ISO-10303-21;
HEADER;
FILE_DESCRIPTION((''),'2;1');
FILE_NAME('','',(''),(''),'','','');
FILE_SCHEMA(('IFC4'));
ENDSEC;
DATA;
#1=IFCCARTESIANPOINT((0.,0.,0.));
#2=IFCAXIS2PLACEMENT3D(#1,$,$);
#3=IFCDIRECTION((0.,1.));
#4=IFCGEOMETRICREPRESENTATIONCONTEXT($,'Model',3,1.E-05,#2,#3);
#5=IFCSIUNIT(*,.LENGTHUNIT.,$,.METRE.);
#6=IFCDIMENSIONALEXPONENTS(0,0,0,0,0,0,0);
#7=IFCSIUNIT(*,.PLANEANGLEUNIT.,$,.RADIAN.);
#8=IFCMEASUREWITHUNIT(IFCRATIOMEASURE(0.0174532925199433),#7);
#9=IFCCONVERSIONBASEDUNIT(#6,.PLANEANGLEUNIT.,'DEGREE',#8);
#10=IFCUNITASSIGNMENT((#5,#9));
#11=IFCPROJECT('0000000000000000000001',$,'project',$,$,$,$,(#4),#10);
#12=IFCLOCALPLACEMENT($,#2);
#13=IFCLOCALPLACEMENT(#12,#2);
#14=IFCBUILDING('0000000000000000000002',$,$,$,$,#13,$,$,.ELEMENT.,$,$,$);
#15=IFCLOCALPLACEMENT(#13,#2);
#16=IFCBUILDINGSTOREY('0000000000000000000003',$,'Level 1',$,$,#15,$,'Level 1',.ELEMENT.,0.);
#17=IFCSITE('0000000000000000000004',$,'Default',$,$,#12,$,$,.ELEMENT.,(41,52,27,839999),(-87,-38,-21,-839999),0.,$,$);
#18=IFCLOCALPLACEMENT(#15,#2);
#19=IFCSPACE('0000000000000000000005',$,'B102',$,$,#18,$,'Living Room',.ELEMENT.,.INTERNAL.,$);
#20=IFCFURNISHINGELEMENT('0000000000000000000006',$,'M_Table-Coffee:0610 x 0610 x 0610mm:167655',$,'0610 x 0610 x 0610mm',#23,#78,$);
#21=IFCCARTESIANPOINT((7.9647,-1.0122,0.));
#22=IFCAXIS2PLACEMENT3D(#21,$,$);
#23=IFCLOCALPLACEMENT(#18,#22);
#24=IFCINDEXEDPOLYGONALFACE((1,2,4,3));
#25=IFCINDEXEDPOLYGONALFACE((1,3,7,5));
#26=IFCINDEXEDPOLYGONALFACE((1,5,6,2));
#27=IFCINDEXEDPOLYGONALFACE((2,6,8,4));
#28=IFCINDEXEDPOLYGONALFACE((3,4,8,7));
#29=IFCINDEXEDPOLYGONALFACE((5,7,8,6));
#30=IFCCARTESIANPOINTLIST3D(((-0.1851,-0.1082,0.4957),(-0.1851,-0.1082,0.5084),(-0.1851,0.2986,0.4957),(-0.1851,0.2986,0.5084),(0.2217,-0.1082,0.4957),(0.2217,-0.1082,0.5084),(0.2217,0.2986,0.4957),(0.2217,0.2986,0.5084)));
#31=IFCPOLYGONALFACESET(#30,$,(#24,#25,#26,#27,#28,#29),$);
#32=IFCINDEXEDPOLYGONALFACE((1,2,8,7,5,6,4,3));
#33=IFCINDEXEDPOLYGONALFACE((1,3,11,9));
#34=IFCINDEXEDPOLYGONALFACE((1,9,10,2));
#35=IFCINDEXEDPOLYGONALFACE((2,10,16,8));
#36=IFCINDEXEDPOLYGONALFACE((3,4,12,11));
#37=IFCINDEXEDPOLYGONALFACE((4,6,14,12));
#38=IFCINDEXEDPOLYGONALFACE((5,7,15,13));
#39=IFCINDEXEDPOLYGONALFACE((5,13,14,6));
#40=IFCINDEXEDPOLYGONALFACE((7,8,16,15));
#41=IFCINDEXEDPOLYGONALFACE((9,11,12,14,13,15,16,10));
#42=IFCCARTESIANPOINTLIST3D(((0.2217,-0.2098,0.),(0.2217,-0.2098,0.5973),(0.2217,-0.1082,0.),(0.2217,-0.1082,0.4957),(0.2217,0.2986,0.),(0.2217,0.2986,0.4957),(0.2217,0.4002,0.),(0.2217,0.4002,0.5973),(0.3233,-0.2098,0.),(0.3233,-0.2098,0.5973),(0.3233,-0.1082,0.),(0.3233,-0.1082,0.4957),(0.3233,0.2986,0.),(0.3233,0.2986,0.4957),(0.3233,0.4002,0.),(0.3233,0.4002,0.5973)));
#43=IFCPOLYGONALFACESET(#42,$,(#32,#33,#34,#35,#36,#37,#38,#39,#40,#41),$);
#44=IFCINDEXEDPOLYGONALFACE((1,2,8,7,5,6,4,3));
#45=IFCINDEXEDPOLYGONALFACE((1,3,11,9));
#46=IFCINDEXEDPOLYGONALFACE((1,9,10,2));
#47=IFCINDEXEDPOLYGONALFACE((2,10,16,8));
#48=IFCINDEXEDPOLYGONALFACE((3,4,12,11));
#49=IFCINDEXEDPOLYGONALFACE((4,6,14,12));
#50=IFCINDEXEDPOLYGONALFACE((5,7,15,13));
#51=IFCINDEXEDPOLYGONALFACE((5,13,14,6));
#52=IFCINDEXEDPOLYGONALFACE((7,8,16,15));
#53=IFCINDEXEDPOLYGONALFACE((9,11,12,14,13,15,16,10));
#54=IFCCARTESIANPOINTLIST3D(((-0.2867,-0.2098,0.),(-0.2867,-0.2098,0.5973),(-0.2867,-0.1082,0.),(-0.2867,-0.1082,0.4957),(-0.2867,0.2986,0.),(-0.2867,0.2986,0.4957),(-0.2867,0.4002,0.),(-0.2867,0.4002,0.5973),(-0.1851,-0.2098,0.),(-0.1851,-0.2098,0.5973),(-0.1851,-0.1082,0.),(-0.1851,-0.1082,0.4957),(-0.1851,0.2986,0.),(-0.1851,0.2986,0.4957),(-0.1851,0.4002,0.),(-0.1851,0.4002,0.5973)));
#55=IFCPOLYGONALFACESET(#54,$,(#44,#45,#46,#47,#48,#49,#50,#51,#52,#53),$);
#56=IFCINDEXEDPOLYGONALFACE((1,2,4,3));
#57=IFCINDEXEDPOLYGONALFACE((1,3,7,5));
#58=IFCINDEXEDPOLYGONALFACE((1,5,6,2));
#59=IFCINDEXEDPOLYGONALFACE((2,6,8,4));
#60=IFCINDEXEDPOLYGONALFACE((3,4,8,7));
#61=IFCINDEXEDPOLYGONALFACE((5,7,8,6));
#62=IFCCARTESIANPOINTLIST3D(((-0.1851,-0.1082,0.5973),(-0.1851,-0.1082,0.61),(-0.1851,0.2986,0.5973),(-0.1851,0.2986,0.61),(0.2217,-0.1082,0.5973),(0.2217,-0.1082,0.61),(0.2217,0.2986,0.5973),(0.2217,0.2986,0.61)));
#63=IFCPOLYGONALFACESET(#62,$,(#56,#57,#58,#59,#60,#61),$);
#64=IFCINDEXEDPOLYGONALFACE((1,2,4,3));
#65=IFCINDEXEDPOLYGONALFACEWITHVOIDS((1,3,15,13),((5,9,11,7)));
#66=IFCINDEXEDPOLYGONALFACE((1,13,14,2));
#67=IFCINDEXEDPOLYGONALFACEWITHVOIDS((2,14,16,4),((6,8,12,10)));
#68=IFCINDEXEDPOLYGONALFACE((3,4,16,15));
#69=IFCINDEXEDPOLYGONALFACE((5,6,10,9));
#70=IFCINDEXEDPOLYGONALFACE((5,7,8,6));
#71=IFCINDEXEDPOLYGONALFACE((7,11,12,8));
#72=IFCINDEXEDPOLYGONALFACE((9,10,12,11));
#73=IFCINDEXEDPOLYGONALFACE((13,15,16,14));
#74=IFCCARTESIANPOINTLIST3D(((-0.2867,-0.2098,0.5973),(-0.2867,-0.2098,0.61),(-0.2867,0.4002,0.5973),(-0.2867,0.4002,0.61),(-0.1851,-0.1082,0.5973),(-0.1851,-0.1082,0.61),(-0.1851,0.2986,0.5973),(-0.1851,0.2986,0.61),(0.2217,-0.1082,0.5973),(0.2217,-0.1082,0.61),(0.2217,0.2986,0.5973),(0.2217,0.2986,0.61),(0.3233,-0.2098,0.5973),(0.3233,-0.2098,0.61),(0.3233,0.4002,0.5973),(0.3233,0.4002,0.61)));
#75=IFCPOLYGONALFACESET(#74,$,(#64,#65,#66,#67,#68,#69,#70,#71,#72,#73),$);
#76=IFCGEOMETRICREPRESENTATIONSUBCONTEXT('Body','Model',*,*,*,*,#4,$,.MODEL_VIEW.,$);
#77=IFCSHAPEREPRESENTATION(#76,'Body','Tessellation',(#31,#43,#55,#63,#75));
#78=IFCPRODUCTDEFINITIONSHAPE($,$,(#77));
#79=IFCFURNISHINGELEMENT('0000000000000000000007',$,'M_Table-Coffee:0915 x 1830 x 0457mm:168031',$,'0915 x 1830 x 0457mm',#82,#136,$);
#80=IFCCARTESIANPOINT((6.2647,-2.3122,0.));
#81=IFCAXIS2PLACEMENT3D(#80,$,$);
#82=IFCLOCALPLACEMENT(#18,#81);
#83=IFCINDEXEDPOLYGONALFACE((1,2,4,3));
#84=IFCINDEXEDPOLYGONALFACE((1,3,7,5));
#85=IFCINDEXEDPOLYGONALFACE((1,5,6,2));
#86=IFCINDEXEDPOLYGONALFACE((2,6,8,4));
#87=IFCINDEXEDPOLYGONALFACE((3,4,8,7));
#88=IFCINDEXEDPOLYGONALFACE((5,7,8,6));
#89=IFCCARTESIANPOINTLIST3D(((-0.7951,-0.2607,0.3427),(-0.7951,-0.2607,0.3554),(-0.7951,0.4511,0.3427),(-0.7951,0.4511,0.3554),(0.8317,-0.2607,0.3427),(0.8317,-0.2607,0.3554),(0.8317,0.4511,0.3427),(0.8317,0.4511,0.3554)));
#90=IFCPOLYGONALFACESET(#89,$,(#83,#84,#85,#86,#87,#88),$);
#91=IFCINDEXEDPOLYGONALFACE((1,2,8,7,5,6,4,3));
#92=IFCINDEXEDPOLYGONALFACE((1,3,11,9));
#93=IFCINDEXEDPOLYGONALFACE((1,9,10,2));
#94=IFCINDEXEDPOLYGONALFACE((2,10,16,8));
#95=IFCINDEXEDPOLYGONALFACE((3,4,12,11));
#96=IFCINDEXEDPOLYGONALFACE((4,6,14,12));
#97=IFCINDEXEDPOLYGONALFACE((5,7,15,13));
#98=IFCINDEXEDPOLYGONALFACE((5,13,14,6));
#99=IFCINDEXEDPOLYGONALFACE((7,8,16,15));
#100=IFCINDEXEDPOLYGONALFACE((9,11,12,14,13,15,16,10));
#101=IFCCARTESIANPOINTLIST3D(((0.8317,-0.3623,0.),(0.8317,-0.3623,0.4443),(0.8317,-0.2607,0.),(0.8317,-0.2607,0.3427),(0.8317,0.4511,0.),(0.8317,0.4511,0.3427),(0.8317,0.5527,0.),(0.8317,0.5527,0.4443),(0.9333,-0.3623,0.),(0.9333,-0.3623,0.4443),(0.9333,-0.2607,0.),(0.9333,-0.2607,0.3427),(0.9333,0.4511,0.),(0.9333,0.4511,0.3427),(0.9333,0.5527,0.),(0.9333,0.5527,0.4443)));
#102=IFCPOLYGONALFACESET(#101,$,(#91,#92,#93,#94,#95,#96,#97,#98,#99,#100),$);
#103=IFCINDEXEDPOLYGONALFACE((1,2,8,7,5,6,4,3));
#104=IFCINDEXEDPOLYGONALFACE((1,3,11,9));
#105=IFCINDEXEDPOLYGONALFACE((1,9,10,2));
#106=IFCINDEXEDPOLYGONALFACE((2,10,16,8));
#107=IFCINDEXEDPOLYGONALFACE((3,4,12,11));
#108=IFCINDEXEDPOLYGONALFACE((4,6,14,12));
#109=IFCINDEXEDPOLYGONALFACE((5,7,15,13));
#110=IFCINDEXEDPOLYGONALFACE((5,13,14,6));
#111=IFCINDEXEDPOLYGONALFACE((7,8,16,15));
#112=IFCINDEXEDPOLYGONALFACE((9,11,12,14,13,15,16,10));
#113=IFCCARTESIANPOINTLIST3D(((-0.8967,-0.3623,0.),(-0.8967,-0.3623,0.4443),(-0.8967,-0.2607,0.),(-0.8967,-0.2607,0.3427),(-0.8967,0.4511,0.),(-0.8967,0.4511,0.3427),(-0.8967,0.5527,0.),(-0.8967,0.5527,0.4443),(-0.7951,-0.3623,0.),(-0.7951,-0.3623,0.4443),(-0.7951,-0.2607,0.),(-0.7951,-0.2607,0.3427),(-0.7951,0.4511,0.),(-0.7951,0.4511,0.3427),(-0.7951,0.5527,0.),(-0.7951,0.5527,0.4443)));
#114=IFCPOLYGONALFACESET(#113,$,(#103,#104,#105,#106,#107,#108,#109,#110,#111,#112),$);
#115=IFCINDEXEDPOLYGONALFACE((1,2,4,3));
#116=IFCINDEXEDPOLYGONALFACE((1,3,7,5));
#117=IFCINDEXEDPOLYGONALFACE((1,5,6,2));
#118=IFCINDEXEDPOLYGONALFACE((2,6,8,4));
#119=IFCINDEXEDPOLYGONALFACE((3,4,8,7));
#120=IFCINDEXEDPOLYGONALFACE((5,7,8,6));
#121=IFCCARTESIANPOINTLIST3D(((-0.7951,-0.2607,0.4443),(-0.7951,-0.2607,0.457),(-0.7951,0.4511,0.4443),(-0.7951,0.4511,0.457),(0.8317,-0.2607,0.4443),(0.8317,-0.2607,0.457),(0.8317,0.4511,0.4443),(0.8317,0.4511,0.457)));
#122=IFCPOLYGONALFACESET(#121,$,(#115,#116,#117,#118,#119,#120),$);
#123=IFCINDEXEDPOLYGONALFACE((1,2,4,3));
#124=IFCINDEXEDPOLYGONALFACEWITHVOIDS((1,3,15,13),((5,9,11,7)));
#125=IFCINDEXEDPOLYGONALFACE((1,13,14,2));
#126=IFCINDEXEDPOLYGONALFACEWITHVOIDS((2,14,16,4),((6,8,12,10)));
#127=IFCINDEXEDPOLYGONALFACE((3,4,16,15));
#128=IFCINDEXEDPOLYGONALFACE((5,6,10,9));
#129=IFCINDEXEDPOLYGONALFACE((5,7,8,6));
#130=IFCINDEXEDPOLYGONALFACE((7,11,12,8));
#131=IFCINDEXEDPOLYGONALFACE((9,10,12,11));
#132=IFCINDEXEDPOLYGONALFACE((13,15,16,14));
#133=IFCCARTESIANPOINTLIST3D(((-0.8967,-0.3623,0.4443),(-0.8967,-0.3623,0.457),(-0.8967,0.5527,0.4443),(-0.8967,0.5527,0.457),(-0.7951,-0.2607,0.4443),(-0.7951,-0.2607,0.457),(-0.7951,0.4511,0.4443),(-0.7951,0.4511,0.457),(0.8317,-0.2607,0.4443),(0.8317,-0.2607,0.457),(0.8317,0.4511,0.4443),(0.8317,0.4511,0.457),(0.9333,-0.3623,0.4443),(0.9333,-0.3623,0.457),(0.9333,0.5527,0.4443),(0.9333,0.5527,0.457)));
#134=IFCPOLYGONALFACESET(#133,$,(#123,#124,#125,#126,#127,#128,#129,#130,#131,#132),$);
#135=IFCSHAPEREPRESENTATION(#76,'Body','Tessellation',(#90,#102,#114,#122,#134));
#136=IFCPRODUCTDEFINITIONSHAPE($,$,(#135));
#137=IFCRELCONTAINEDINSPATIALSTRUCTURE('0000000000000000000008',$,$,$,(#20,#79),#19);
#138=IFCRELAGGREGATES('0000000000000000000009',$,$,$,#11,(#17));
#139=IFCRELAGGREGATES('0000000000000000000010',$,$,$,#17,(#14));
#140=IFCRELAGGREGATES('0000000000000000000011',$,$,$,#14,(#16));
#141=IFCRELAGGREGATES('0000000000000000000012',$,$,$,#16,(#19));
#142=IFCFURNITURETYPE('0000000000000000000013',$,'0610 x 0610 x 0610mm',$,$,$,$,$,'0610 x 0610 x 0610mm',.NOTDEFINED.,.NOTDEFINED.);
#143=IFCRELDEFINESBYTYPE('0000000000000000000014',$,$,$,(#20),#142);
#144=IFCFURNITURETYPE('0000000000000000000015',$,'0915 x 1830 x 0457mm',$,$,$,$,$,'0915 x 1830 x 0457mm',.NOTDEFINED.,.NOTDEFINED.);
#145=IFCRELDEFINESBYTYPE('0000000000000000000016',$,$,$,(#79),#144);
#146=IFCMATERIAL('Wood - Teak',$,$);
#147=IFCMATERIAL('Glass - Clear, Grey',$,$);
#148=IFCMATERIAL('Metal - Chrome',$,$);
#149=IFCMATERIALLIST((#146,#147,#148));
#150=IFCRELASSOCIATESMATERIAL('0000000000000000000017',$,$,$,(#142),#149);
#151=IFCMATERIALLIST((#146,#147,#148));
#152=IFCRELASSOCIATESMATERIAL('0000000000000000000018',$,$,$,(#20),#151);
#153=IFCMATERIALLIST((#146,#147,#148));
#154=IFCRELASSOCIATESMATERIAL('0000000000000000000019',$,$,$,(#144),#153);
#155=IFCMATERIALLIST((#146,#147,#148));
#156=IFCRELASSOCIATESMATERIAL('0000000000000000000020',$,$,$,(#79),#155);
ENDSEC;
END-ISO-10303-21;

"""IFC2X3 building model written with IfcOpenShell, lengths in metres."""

from ifc_helpers import new_model, entity, si_unit, converted_unit, direction, frame, origin, origin_2d_with_axis, place, context, subcontext, project, spatial, polyline, rectangle, outline, extrude, source, transform, mapped, material, material_list, type_object, type_shapes, element, save


model = new_model("IFC2X3")

# Units and contexts
model_context = context("Model", 3, precision=1e-05, world=origin(), true_north=direction((0.0, 1.0)))
body_context = subcontext(model_context, "Body", "Model", "MODEL_VIEW")
ifc_project = project(units=[si_unit("LENGTHUNIT", "METRE"), converted_unit("PLANEANGLEUNIT", "DEGREE", entity("IfcRatioMeasure", 0.0174532925199433), si_unit("PLANEANGLEUNIT", "RADIAN"), dimensions=[0, 0, 0, 0, 0, 0, 0])], contexts=[model_context])

# Site, building, storey
site_placement = place(None, origin())
site = spatial("IfcSite", under=ifc_project, at=site_placement, Name="Default", CompositionType="ELEMENT", RefLatitude=(41, 52, 27, 839999), RefLongitude=(-87, -38, -21, -839999), RefElevation=0.0)
building_placement = place(site_placement, origin())
building = spatial("IfcBuilding", under=site, at=building_placement, CompositionType="ELEMENT")
storey_placement = place(building_placement, origin())
storey = spatial("IfcBuildingStorey", under=building, at=storey_placement, Name="Level 1", LongName="Level 1", CompositionType="ELEMENT", Elevation=0.0)

# Shared definitions
space_placement = place(storey_placement, origin())
space = spatial("IfcSpace", under=storey, at=space_placement, Name="B102", LongName="Living Room", CompositionType="ELEMENT", InteriorOrExteriorSpace="INTERNAL")

# Furnishing elements
ifc_material_1 = material(Name="Wood - Teak")
ifc_material_2 = material(Name="Glass - Clear, Grey")
ifc_material_3 = material(Name="Metal - Chrome")
ifc_material_list_1 = material_list([ifc_material_1, ifc_material_2, ifc_material_3])
ifc_material_list_2 = material_list([ifc_material_1, ifc_material_2, ifc_material_3])
furniture_type_1 = type_object("IfcFurnitureType", Name="0610 x 0610 x 0610mm", ElementType="0610 x 0610 x 0610mm", AssemblyPlace="NOTDEFINED", material=ifc_material_list_2)
shared_shape_1 = source(origin(), body_context, "Body", "SweptSolid", [
    extrude(rectangle(XDim=0.4068, YDim=0.4068, at=origin_2d_with_axis()), frame((0.0183, 0.0952, 0.4957), z_axis=(0.0, 0.0, 1.0), x_axis=(-1.0, 0.0, 0.0)), (0.0, 0.0, 1.0), 0.0127),
    extrude(outline(polyline([(-0.2732, -0.305), (0.324, -0.305), (0.324, 0.305), (-0.2732, 0.305), (-0.2732, 0.2034), (0.2225, 0.2034), (0.2225, -0.2034), (-0.2732, -0.2034), (-0.2732, -0.305)])), frame((0.2217, 0.0952, 0.2732), z_axis=(1.0, 0.0, 0.0), x_axis=(0.0, 0.0, 1.0)), (0.0, 0.0, 1.0), 0.1016),
    extrude(outline(polyline([(-0.305, -0.3241), (0.305, -0.3241), (0.305, 0.2733), (0.2034, 0.2733), (0.2034, -0.2224), (-0.2034, -0.2224), (-0.2034, 0.2733), (-0.305, 0.2733), (-0.305, -0.3241)])), frame((-0.2867, 0.0952, 0.2733), z_axis=(1.0, 0.0, 0.0), x_axis=(0.0, -1.0, 0.0)), (0.0, 0.0, 1.0), 0.1016),
    extrude(rectangle(XDim=0.4068, YDim=0.4068, at=origin_2d_with_axis()), frame((0.0183, 0.0952, 0.5973), z_axis=(0.0, 0.0, 1.0), x_axis=(-1.0, 0.0, 0.0)), (0.0, 0.0, 1.0), 0.0127),
    extrude(outline(polyline([(-0.305, -0.305), (0.305, -0.305), (0.305, 0.305), (-0.305, 0.305), (-0.305, -0.305)]), holes=[polyline([(-0.2034, -0.2034), (-0.2034, 0.2034), (0.2034, 0.2034), (0.2034, -0.2034), (-0.2034, -0.2034)])]), frame((0.0183, 0.0952, 0.5973), z_axis=(0.0, 0.0, 1.0), x_axis=(-1.0, 0.0, 0.0)), (0.0, 0.0, 1.0), 0.0127),
])
type_shapes(furniture_type_1, [shared_shape_1])
furnishing_1_placement = place(space_placement, frame((7.9647, -1.0122, 0.0)))
element("IfcFurnishingElement", 1, at=furnishing_1_placement, inside=space, type_object=furniture_type_1, material=ifc_material_list_1, Name="M_Table-Coffee:0610 x 0610 x 0610mm:167655", ObjectType="0610 x 0610 x 0610mm", context=body_context, shape_type="MappedRepresentation", body=[
    mapped(shared_shape_1, transform((0.0, 0.0, 0.0), scale=1.0)),
])
ifc_material_list_3 = material_list([ifc_material_1, ifc_material_2, ifc_material_3])
ifc_material_list_4 = material_list([ifc_material_1, ifc_material_2, ifc_material_3])
furniture_type_2 = type_object("IfcFurnitureType", Name="0915 x 1830 x 0457mm", ElementType="0915 x 1830 x 0457mm", AssemblyPlace="NOTDEFINED", material=ifc_material_list_4)
shared_shape_2 = source(origin(), body_context, "Body", "SweptSolid", [
    extrude(rectangle(XDim=1.6268, YDim=0.7118, at=origin_2d_with_axis()), frame((0.0183, 0.0952, 0.3427), z_axis=(0.0, 0.0, 1.0), x_axis=(-1.0, 0.0, 0.0)), (0.0, 0.0, 1.0), 0.0127),
    extrude(outline(polyline([(-0.1967, -0.4575), (0.2475, -0.4575), (0.2475, 0.4575), (-0.1967, 0.4575), (-0.1967, 0.3559), (0.146, 0.3559), (0.146, -0.3559), (-0.1967, -0.3559), (-0.1967, -0.4575)])), frame((0.8317, 0.0952, 0.1967), z_axis=(1.0, 0.0, 0.0), x_axis=(0.0, 0.0, 1.0)), (0.0, 0.0, 1.0), 0.1016),
    extrude(outline(polyline([(-0.4575, -0.2476), (0.4575, -0.2476), (0.4575, 0.1968), (0.3559, 0.1968), (0.3559, -0.1459), (-0.3559, -0.1459), (-0.3559, 0.1968), (-0.4575, 0.1968), (-0.4575, -0.2476)])), frame((-0.8967, 0.0952, 0.1968), z_axis=(1.0, 0.0, 0.0), x_axis=(0.0, -1.0, 0.0)), (0.0, 0.0, 1.0), 0.1016),
    extrude(rectangle(XDim=1.6268, YDim=0.7118, at=origin_2d_with_axis()), frame((0.0183, 0.0952, 0.4443), z_axis=(0.0, 0.0, 1.0), x_axis=(-1.0, 0.0, 0.0)), (0.0, 0.0, 1.0), 0.0127),
    extrude(outline(polyline([(-0.915, -0.4575), (0.915, -0.4575), (0.915, 0.4575), (-0.915, 0.4575), (-0.915, -0.4575)]), holes=[polyline([(-0.8134, -0.3559), (-0.8134, 0.3559), (0.8134, 0.3559), (0.8134, -0.3559), (-0.8134, -0.3559)])]), frame((0.0183, 0.0952, 0.4443), z_axis=(0.0, 0.0, 1.0), x_axis=(-1.0, 0.0, 0.0)), (0.0, 0.0, 1.0), 0.0127),
])
type_shapes(furniture_type_2, [shared_shape_2])
furnishing_2_placement = place(space_placement, frame((6.2647, -2.3122, 0.0)))
element("IfcFurnishingElement", 2, at=furnishing_2_placement, inside=space, type_object=furniture_type_2, material=ifc_material_list_3, Name="M_Table-Coffee:0915 x 1830 x 0457mm:168031", ObjectType="0915 x 1830 x 0457mm", context=body_context, shape_type="MappedRepresentation", body=[
    mapped(shared_shape_2, transform((0.0, 0.0, 0.0), scale=1.0)),
])

save(model, "model.ifc")
